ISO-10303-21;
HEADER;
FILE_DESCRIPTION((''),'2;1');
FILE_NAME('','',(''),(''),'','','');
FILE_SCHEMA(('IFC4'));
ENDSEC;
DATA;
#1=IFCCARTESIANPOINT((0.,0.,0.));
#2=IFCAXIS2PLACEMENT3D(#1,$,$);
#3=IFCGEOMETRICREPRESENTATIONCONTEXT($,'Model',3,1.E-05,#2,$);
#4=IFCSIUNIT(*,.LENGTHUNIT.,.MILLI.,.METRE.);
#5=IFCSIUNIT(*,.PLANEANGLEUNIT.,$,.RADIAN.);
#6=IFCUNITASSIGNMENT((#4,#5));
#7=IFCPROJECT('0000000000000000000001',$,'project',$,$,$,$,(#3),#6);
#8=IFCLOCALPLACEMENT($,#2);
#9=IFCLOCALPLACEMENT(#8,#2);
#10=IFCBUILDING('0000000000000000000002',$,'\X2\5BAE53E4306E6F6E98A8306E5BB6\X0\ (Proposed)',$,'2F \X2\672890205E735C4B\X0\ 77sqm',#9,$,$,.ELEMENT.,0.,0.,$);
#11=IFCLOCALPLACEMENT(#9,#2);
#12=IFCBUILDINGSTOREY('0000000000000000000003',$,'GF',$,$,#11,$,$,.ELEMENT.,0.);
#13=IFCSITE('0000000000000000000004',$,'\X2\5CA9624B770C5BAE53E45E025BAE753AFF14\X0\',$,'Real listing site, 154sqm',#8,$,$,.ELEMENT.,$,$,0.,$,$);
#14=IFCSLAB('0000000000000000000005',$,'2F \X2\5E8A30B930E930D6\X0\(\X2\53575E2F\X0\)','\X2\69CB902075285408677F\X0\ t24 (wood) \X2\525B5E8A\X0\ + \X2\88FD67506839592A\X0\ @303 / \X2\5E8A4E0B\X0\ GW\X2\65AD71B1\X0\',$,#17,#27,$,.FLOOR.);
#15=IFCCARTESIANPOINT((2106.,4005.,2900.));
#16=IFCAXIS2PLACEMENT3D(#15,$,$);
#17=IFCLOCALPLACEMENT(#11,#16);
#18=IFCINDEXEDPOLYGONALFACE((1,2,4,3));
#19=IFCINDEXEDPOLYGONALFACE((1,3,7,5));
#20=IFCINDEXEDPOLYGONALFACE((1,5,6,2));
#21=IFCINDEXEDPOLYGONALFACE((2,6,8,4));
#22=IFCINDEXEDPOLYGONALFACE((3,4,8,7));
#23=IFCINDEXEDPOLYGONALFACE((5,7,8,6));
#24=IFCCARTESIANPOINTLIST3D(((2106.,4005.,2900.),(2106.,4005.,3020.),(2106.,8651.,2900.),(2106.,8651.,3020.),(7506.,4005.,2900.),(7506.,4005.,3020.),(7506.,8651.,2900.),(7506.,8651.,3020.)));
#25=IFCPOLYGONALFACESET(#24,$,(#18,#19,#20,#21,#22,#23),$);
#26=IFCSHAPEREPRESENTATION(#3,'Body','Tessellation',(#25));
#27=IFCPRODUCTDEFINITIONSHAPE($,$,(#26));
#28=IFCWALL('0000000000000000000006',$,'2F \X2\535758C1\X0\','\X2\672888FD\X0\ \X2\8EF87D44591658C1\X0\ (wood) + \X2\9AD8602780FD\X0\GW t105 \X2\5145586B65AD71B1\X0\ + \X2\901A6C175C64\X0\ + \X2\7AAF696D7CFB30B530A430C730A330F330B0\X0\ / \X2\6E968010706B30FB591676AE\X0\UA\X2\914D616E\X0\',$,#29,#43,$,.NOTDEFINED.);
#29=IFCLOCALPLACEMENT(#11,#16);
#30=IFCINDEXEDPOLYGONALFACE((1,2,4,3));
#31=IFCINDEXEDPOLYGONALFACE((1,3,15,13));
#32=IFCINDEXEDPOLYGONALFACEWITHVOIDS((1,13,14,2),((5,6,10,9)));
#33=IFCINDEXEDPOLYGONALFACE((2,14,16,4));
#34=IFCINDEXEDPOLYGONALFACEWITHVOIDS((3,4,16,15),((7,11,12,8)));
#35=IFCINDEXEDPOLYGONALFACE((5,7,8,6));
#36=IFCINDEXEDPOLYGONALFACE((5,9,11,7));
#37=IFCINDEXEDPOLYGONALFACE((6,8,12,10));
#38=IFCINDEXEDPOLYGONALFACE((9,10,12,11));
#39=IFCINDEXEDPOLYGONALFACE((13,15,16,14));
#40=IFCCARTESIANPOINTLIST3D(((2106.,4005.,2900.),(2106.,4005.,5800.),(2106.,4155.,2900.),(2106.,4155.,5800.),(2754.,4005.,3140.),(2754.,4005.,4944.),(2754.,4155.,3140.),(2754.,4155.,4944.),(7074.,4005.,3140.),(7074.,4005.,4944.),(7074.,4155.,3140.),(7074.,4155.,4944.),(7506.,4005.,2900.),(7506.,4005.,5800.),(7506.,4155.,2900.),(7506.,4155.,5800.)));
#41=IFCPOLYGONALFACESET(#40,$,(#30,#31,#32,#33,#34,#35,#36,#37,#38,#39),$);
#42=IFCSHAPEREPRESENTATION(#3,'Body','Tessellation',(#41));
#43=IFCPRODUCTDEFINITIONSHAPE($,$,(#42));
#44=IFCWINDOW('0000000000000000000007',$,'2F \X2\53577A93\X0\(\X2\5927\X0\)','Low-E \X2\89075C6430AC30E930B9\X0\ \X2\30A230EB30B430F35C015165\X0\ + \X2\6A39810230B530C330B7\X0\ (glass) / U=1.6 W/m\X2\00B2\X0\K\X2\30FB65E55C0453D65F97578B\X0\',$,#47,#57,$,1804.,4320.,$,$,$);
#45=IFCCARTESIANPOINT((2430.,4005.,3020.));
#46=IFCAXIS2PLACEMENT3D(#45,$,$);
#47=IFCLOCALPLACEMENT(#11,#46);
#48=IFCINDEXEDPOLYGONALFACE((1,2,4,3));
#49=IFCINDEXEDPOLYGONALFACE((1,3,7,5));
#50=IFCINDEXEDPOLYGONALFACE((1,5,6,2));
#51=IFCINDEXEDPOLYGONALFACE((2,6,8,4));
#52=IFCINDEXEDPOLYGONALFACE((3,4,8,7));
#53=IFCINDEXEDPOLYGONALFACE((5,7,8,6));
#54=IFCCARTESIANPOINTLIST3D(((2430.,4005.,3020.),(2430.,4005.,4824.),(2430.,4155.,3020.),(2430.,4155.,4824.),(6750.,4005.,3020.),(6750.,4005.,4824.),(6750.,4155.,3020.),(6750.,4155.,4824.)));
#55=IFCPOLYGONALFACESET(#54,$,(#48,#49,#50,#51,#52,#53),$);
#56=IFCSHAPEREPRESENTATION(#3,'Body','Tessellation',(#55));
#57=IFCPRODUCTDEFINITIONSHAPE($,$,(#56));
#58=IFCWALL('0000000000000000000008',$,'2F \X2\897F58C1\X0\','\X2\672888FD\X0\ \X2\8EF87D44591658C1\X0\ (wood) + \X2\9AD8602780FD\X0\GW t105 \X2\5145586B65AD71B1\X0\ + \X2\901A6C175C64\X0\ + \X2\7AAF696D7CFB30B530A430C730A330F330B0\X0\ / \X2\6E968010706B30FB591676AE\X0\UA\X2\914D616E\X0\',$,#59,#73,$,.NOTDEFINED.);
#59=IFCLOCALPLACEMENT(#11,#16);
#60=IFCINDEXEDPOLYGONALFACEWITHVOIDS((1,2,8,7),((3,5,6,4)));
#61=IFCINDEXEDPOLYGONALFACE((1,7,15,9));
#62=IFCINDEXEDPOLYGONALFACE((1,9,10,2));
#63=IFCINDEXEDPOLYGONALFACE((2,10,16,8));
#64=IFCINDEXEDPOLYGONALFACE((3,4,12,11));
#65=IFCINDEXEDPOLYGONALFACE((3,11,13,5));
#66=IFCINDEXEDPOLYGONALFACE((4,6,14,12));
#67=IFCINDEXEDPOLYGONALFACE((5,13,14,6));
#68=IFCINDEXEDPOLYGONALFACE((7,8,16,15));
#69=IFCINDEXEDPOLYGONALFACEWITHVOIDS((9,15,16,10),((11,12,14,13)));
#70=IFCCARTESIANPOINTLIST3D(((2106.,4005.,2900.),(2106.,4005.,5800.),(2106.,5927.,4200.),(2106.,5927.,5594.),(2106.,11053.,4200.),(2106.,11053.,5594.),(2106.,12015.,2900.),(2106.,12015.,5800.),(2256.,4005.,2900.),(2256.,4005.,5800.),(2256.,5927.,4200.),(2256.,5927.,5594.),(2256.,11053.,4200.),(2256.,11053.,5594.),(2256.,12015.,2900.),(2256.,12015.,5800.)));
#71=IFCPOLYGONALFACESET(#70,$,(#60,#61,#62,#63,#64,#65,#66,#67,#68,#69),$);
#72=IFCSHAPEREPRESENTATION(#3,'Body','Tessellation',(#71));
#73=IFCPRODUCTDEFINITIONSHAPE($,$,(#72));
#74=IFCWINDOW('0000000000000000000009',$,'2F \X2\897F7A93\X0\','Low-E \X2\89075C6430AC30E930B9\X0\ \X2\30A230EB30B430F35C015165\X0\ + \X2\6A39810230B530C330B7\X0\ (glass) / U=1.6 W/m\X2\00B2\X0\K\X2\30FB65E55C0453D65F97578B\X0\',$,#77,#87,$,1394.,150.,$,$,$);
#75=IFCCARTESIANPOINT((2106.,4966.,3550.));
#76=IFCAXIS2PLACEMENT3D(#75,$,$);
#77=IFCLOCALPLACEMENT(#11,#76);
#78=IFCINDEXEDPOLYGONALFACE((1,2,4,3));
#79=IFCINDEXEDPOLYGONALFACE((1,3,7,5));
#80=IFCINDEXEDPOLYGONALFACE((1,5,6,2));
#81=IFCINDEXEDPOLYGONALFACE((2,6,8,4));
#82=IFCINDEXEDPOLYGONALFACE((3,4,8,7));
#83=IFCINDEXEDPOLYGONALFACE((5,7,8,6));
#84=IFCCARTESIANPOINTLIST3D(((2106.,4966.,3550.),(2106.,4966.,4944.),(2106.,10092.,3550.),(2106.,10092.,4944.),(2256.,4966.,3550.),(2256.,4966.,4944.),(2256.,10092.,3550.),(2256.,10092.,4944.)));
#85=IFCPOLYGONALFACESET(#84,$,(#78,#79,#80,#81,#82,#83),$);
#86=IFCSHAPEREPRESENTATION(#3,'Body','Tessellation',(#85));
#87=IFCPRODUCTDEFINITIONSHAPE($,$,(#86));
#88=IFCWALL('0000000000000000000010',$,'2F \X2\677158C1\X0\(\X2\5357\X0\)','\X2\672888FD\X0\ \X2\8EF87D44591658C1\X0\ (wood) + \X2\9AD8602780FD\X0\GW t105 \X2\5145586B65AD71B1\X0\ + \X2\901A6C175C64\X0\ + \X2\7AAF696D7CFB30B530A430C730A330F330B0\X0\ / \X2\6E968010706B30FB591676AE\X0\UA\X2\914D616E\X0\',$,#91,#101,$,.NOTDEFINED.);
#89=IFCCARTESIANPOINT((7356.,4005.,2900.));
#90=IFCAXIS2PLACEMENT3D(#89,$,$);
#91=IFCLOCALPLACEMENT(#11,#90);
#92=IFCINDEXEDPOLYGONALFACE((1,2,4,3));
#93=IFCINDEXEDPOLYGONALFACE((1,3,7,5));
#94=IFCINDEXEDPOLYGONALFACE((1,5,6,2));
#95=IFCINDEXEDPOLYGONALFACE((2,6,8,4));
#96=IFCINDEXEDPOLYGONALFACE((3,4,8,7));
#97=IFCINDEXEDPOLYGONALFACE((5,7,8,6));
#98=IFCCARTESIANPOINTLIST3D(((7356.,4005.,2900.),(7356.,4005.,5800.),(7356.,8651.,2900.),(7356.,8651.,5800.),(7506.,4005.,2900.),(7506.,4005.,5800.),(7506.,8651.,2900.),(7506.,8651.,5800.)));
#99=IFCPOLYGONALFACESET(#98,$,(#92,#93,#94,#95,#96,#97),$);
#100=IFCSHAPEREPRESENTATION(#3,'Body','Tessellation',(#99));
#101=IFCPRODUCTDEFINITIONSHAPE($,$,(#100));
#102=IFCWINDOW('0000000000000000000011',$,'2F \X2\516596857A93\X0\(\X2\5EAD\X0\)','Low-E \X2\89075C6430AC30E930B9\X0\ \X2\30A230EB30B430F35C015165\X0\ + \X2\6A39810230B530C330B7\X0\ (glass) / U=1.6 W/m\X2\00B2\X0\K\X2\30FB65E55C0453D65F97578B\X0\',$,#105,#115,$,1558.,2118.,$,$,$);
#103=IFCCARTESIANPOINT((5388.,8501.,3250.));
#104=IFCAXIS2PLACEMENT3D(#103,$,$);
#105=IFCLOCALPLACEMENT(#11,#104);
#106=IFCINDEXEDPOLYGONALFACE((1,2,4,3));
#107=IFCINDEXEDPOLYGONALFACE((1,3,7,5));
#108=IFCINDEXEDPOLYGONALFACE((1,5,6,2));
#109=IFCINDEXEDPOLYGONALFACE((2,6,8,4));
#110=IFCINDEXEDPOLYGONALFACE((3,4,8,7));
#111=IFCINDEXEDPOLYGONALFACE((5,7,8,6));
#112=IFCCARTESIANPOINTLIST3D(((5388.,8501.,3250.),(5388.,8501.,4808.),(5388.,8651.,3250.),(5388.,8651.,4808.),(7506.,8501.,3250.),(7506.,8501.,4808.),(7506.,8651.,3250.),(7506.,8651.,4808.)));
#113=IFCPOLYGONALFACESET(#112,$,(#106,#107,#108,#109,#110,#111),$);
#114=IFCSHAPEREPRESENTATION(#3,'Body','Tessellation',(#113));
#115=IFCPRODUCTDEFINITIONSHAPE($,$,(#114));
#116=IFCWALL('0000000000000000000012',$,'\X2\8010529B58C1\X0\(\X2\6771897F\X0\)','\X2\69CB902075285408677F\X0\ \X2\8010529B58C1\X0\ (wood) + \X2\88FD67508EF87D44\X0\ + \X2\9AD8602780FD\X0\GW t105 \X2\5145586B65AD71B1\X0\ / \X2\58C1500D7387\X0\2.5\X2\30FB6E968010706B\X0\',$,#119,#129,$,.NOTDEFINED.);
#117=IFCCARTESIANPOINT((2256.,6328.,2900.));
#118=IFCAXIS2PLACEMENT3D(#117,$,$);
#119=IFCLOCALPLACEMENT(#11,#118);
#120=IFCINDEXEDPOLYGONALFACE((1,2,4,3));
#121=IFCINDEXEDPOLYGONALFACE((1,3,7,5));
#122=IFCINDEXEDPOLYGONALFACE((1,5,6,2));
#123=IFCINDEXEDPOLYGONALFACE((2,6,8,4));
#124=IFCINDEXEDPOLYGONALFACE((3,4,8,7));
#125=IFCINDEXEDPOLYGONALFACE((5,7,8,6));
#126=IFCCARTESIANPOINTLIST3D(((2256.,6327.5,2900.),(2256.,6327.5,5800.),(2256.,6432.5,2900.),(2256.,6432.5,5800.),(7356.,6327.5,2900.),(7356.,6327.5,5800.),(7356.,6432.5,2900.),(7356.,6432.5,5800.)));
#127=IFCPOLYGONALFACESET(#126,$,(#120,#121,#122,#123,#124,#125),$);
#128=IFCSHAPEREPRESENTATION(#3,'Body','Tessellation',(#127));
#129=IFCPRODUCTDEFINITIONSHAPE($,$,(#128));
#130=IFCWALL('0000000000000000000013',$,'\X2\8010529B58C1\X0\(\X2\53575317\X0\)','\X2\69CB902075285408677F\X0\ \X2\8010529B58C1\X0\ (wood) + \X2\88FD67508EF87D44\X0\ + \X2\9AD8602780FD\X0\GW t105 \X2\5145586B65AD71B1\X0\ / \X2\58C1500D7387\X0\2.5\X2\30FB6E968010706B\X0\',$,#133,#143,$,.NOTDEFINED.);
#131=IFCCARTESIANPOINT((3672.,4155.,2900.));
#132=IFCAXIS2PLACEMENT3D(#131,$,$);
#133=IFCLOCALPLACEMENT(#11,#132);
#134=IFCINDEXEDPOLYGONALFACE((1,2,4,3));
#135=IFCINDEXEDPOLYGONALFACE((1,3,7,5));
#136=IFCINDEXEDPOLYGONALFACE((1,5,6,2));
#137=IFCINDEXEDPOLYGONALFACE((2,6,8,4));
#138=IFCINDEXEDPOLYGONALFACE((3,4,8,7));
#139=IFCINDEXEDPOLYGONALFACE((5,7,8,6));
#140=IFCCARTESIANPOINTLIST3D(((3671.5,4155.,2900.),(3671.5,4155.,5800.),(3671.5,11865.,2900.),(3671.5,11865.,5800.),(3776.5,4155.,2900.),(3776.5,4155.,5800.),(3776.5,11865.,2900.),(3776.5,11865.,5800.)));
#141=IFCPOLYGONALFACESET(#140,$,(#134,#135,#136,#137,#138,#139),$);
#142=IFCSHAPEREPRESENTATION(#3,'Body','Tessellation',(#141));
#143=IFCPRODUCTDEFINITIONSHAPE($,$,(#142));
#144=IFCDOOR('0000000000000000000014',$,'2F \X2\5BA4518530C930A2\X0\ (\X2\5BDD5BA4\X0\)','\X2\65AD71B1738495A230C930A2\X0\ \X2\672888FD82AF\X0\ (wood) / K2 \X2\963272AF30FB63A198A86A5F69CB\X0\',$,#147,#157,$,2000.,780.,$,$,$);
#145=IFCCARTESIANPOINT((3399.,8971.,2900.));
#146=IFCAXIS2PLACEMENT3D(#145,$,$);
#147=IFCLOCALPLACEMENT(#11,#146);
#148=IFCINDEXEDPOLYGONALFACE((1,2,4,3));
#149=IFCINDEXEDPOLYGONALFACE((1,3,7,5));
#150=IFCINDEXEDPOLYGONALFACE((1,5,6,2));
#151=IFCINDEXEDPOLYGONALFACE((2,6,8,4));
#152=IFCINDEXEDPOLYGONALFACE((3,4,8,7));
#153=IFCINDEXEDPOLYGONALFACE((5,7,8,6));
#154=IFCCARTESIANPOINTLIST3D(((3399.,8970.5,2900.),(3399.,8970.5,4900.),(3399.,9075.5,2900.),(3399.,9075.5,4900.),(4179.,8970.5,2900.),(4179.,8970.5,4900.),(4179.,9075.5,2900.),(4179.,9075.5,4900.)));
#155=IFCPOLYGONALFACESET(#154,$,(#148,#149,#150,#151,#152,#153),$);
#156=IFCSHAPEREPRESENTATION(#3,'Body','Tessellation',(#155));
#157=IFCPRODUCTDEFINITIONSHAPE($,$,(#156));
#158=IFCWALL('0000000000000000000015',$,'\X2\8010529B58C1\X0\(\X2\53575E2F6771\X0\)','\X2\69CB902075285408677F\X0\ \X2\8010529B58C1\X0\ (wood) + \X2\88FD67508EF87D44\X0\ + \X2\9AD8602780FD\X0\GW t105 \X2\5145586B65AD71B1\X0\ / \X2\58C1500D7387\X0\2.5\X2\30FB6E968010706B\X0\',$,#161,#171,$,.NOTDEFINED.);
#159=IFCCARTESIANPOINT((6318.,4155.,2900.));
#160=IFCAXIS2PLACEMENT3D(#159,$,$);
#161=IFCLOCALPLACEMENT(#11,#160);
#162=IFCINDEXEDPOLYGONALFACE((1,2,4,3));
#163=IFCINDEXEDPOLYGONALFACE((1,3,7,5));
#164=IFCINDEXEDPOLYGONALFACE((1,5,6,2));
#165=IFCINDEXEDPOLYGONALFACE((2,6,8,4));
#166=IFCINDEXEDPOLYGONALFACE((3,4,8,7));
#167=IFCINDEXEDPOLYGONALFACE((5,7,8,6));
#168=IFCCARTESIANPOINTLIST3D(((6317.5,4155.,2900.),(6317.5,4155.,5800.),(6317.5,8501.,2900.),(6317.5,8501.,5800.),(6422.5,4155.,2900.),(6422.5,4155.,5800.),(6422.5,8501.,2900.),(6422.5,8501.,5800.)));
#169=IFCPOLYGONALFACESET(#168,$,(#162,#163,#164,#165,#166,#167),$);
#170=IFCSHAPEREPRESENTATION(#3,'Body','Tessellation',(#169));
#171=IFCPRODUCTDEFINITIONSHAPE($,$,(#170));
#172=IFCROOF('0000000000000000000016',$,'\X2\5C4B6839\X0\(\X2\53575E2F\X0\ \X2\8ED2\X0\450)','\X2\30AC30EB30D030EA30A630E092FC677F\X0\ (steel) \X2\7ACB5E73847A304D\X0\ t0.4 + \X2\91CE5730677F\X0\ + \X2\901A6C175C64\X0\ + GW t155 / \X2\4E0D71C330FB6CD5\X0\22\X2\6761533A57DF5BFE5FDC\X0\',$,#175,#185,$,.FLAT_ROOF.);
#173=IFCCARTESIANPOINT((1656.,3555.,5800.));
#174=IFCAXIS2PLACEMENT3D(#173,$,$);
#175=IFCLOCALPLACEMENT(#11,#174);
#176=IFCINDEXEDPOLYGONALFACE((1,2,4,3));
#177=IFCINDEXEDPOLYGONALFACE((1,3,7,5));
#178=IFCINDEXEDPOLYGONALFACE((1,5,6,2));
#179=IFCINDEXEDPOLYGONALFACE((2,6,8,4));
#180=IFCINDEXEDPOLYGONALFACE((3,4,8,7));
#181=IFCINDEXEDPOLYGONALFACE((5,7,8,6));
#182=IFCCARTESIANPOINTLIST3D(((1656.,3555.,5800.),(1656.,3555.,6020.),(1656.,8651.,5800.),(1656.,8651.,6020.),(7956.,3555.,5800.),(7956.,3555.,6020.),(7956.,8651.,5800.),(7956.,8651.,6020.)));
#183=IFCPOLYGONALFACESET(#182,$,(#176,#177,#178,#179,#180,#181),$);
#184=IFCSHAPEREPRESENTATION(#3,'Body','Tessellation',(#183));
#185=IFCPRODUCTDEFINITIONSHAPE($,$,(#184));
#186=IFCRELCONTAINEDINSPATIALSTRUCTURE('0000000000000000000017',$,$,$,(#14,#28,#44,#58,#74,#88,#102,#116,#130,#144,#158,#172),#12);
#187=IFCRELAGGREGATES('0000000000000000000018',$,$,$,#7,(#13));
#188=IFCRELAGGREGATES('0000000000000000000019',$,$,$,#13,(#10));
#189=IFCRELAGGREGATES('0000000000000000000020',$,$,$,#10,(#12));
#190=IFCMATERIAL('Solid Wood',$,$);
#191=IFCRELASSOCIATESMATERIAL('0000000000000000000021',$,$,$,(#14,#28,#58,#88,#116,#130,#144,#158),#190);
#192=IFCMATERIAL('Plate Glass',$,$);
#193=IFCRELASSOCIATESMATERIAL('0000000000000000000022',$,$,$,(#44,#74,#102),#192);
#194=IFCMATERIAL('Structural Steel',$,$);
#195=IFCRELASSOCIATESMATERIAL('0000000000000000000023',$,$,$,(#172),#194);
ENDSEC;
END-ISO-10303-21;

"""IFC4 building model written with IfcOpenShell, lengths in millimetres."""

from ifc_helpers import new_model, si_unit, frame, frame_2d, origin, place, context, project, spatial, rectangle, extrude, material, element, fill, save


model = new_model("IFC4")

# Units and contexts
model_context = context("Model", 3, precision=1e-05, world=origin())
ifc_project = project(units=[si_unit("LENGTHUNIT", "METRE", prefix="MILLI"), si_unit("PLANEANGLEUNIT", "RADIAN")], contexts=[model_context])

# Site, building, storey
site_placement = place(None, origin())
site = spatial("IfcSite", under=ifc_project, at=site_placement, Name="岩手県宮古市宮町４", ObjectType="Real listing site, 154sqm", CompositionType="ELEMENT", RefElevation=0.0)
building_placement = place(site_placement, origin())
building = spatial("IfcBuilding", under=site, at=building_placement, Name="宮古の潮風の家 (Proposed)", ObjectType="2F 木造平屋 77sqm", CompositionType="ELEMENT", ElevationOfRefHeight=0.0, ElevationOfTerrain=0.0)
storey_placement = place(building_placement, origin())
storey = spatial("IfcBuildingStorey", under=building, at=storey_placement, Name="GF", CompositionType="ELEMENT", Elevation=0.0)

# Slab
ifc_material_1 = material(Name="Solid Wood")
slab_placement = place(storey_placement, frame((2106.0, 4005.0, 2900.0)))
element("IfcSlab", 1, at=slab_placement, inside=storey, material=ifc_material_1, Name="2F 床スラブ(南帯)", Description="構造用合板 t24 (wood) 剛床 + 製材根太 @303 / 床下 GW断熱", PredefinedType="FLOOR", context=model_context, shape_type="SweptSolid", body=[
    extrude(rectangle(XDim=5400.0, YDim=4646.0, at=frame_2d((2700.0, 2323.0))), frame((2106.0, 4005.0, 2900.0)), (0.0, 0.0, 1.0), 120.0),
])

# Walls, openings, windows
wall_1_placement = place(storey_placement, frame((2106.0, 4005.0, 2900.0)))
wall_1 = element("IfcWall", 2, at=wall_1_placement, inside=storey, material=ifc_material_1, Name="2F 南壁", Description="木製 軸組外壁 (wood) + 高性能GW t105 充填断熱 + 通気層 + 窯業系サイディング / 準耐火・外皮UA配慮", PredefinedType="NOTDEFINED", context=model_context, shape_type="SweptSolid", body=[
    extrude(rectangle(XDim=5400.0, YDim=150.0, at=frame_2d((2700.0, 75.0))), frame((2106.0, 4005.0, 2900.0)), (0.0, 0.0, 1.0), 2900.0),
])
opening_1_placement = place(storey_placement, frame((2430.0, 4005.0, 3020.0)))
opening_1 = element("IfcOpeningElement", 3, at=opening_1_placement, cuts=wall_1, PredefinedType="NOTDEFINED", context=model_context, shape_type="SweptSolid", body=[
    extrude(rectangle(XDim=4320.0, YDim=150.0, at=frame_2d((2160.0, 75.0))), frame((2430.0, 4005.0, 3020.0)), (0.0, 0.0, 1.0), 1804.0),
])
ifc_material_2 = material(Name="Plate Glass")
window_1_placement = place(storey_placement, frame((2430.0, 4005.0, 3020.0)))
window_1 = element("IfcWindow", 4, at=window_1_placement, inside=storey, material=ifc_material_2, Name="2F 南窓(大)", Description="Low-E 複層ガラス アルゴン封入 + 樹脂サッシ (glass) / U=1.6 W/m²K・日射取得型", OverallHeight=1804.0, OverallWidth=4320.0, context=model_context, shape_type="SweptSolid", body=[
    extrude(rectangle(XDim=4320.0, YDim=150.0, at=frame_2d((2160.0, 75.0))), frame((2430.0, 4005.0, 3020.0)), (0.0, 0.0, 1.0), 1804.0),
])
fill(opening_1, window_1)
wall_2_placement = place(storey_placement, frame((2106.0, 4005.0, 2900.0)))
wall_2 = element("IfcWall", 5, at=wall_2_placement, inside=storey, material=ifc_material_1, Name="2F 西壁", Description="木製 軸組外壁 (wood) + 高性能GW t105 充填断熱 + 通気層 + 窯業系サイディング / 準耐火・外皮UA配慮", PredefinedType="NOTDEFINED", context=model_context, shape_type="SweptSolid", body=[
    extrude(rectangle(XDim=150.0, YDim=8010.0, at=frame_2d((75.0, 4005.0))), frame((2106.0, 4005.0, 2900.0)), (0.0, 0.0, 1.0), 2900.0),
])
opening_2_placement = place(storey_placement, frame((2106.0, 4966.0, 3550.0)))
opening_2 = element("IfcOpeningElement", 6, at=opening_2_placement, cuts=wall_2, PredefinedType="NOTDEFINED", context=model_context, shape_type="SweptSolid", body=[
    extrude(rectangle(XDim=150.0, YDim=5126.0, at=frame_2d((75.0, 2563.0))), frame((2106.0, 4966.0, 3550.0)), (0.0, 0.0, 1.0), 1394.0),
])
window_2_placement = place(storey_placement, frame((2106.0, 4966.0, 3550.0)))
window_2 = element("IfcWindow", 7, at=window_2_placement, inside=storey, material=ifc_material_2, Name="2F 西窓", Description="Low-E 複層ガラス アルゴン封入 + 樹脂サッシ (glass) / U=1.6 W/m²K・日射取得型", OverallHeight=1394.0, OverallWidth=150.0, context=model_context, shape_type="SweptSolid", body=[
    extrude(rectangle(XDim=150.0, YDim=5126.0, at=frame_2d((75.0, 2563.0))), frame((2106.0, 4966.0, 3550.0)), (0.0, 0.0, 1.0), 1394.0),
])
fill(opening_2, window_2)
wall_3_placement = place(storey_placement, frame((7356.0, 4005.0, 2900.0)))
wall_3 = element("IfcWall", 8, at=wall_3_placement, inside=storey, material=ifc_material_1, Name="2F 東壁(南)", Description="木製 軸組外壁 (wood) + 高性能GW t105 充填断熱 + 通気層 + 窯業系サイディング / 準耐火・外皮UA配慮", PredefinedType="NOTDEFINED", context=model_context, shape_type="SweptSolid", body=[
    extrude(rectangle(XDim=150.0, YDim=4646.0, at=frame_2d((75.0, 2323.0))), frame((7356.0, 4005.0, 2900.0)), (0.0, 0.0, 1.0), 2900.0),
])
opening_3_placement = place(storey_placement, frame((5388.0, 8501.0, 3250.0)))
opening_3 = element("IfcOpeningElement", 9, at=opening_3_placement, cuts=wall_3, PredefinedType="NOTDEFINED", context=model_context, shape_type="SweptSolid", body=[
    extrude(rectangle(XDim=2118.0, YDim=150.0, at=frame_2d((1059.0, 75.0))), frame((5388.0, 8501.0, 3250.0)), (0.0, 0.0, 1.0), 1558.0),
])
window_3_placement = place(storey_placement, frame((5388.0, 8501.0, 3250.0)))
window_3 = element("IfcWindow", 10, at=window_3_placement, inside=storey, material=ifc_material_2, Name="2F 入隅窓(庭)", Description="Low-E 複層ガラス アルゴン封入 + 樹脂サッシ (glass) / U=1.6 W/m²K・日射取得型", OverallHeight=1558.0, OverallWidth=2118.0, context=model_context, shape_type="SweptSolid", body=[
    extrude(rectangle(XDim=2118.0, YDim=150.0, at=frame_2d((1059.0, 75.0))), frame((5388.0, 8501.0, 3250.0)), (0.0, 0.0, 1.0), 1558.0),
])
fill(opening_3, window_3)

# Wall
wall_4_placement = place(storey_placement, frame((2256.0, 6328.0, 2900.0)))
element("IfcWall", 11, at=wall_4_placement, inside=storey, material=ifc_material_1, Name="耐力壁(東西)", Description="構造用合板 耐力壁 (wood) + 製材軸組 + 高性能GW t105 充填断熱 / 壁倍率2.5・準耐火", PredefinedType="NOTDEFINED", context=model_context, shape_type="SweptSolid", body=[
    extrude(rectangle(XDim=5100.0, YDim=105.0, at=frame_2d((2550.0, 52.0))), frame((2256.0, 6328.0, 2900.0)), (0.0, 0.0, 1.0), 2900.0),
])

# Wall, opening, door
wall_5_placement = place(storey_placement, frame((3672.0, 4155.0, 2900.0)))
wall_5 = element("IfcWall", 12, at=wall_5_placement, inside=storey, material=ifc_material_1, Name="耐力壁(南北)", Description="構造用合板 耐力壁 (wood) + 製材軸組 + 高性能GW t105 充填断熱 / 壁倍率2.5・準耐火", PredefinedType="NOTDEFINED", context=model_context, shape_type="SweptSolid", body=[
    extrude(rectangle(XDim=105.0, YDim=7710.0, at=frame_2d((52.0, 3855.0))), frame((3672.0, 4155.0, 2900.0)), (0.0, 0.0, 1.0), 2900.0),
])
opening_4_placement = place(storey_placement, frame((3399.0, 8971.0, 2900.0)))
opening_4 = element("IfcOpeningElement", 13, at=opening_4_placement, cuts=wall_5, PredefinedType="NOTDEFINED", context=model_context, shape_type="SweptSolid", body=[
    extrude(rectangle(XDim=780.0, YDim=105.0, at=frame_2d((390.0, 52.0))), frame((3399.0, 8971.0, 2900.0)), (0.0, 0.0, 1.0), 2000.0),
])
door_placement = place(storey_placement, frame((3399.0, 8971.0, 2900.0)))
door = element("IfcDoor", 14, at=door_placement, inside=storey, material=ifc_material_1, Name="2F 室内ドア (寝室)", Description="断熱玄関ドア 木製芯 (wood) / K2 防犯・採風機構", OverallHeight=2000.0, OverallWidth=780.0, context=model_context, shape_type="SweptSolid", body=[
    extrude(rectangle(XDim=780.0, YDim=105.0, at=frame_2d((390.0, 52.0))), frame((3399.0, 8971.0, 2900.0)), (0.0, 0.0, 1.0), 2000.0),
])
fill(opening_4, door)

# Wall
wall_6_placement = place(storey_placement, frame((6318.0, 4155.0, 2900.0)))
element("IfcWall", 15, at=wall_6_placement, inside=storey, material=ifc_material_1, Name="耐力壁(南帯東)", Description="構造用合板 耐力壁 (wood) + 製材軸組 + 高性能GW t105 充填断熱 / 壁倍率2.5・準耐火", PredefinedType="NOTDEFINED", context=model_context, shape_type="SweptSolid", body=[
    extrude(rectangle(XDim=105.0, YDim=4346.0, at=frame_2d((52.0, 2173.0))), frame((6318.0, 4155.0, 2900.0)), (0.0, 0.0, 1.0), 2900.0),
])

# Roof
ifc_material_3 = material(Name="Structural Steel")
for number, where, name in (
    (16, (1656.0, 3555.0, 5800.0), "屋根(南帯 軒450)"),
):
    element("IfcRoof", number, at=place(storey_placement, frame(where)), inside=storey, material=ifc_material_3, Name=name, Description="ガルバリウム鋼板 (steel) 立平葺き t0.4 + 野地板 + 通気層 + GW t155 / 不燃・法22条区域対応", PredefinedType="FLAT_ROOF", context=model_context, shape_type="SweptSolid", body=[
        extrude(rectangle(XDim=6300.0, YDim=5096.0, at=frame_2d((3150.0, 2548.0))), frame((1656.0, 3555.0, 5800.0)), (0.0, 0.0, 1.0), 220.0),
    ])

save(model, "model.ifc")
